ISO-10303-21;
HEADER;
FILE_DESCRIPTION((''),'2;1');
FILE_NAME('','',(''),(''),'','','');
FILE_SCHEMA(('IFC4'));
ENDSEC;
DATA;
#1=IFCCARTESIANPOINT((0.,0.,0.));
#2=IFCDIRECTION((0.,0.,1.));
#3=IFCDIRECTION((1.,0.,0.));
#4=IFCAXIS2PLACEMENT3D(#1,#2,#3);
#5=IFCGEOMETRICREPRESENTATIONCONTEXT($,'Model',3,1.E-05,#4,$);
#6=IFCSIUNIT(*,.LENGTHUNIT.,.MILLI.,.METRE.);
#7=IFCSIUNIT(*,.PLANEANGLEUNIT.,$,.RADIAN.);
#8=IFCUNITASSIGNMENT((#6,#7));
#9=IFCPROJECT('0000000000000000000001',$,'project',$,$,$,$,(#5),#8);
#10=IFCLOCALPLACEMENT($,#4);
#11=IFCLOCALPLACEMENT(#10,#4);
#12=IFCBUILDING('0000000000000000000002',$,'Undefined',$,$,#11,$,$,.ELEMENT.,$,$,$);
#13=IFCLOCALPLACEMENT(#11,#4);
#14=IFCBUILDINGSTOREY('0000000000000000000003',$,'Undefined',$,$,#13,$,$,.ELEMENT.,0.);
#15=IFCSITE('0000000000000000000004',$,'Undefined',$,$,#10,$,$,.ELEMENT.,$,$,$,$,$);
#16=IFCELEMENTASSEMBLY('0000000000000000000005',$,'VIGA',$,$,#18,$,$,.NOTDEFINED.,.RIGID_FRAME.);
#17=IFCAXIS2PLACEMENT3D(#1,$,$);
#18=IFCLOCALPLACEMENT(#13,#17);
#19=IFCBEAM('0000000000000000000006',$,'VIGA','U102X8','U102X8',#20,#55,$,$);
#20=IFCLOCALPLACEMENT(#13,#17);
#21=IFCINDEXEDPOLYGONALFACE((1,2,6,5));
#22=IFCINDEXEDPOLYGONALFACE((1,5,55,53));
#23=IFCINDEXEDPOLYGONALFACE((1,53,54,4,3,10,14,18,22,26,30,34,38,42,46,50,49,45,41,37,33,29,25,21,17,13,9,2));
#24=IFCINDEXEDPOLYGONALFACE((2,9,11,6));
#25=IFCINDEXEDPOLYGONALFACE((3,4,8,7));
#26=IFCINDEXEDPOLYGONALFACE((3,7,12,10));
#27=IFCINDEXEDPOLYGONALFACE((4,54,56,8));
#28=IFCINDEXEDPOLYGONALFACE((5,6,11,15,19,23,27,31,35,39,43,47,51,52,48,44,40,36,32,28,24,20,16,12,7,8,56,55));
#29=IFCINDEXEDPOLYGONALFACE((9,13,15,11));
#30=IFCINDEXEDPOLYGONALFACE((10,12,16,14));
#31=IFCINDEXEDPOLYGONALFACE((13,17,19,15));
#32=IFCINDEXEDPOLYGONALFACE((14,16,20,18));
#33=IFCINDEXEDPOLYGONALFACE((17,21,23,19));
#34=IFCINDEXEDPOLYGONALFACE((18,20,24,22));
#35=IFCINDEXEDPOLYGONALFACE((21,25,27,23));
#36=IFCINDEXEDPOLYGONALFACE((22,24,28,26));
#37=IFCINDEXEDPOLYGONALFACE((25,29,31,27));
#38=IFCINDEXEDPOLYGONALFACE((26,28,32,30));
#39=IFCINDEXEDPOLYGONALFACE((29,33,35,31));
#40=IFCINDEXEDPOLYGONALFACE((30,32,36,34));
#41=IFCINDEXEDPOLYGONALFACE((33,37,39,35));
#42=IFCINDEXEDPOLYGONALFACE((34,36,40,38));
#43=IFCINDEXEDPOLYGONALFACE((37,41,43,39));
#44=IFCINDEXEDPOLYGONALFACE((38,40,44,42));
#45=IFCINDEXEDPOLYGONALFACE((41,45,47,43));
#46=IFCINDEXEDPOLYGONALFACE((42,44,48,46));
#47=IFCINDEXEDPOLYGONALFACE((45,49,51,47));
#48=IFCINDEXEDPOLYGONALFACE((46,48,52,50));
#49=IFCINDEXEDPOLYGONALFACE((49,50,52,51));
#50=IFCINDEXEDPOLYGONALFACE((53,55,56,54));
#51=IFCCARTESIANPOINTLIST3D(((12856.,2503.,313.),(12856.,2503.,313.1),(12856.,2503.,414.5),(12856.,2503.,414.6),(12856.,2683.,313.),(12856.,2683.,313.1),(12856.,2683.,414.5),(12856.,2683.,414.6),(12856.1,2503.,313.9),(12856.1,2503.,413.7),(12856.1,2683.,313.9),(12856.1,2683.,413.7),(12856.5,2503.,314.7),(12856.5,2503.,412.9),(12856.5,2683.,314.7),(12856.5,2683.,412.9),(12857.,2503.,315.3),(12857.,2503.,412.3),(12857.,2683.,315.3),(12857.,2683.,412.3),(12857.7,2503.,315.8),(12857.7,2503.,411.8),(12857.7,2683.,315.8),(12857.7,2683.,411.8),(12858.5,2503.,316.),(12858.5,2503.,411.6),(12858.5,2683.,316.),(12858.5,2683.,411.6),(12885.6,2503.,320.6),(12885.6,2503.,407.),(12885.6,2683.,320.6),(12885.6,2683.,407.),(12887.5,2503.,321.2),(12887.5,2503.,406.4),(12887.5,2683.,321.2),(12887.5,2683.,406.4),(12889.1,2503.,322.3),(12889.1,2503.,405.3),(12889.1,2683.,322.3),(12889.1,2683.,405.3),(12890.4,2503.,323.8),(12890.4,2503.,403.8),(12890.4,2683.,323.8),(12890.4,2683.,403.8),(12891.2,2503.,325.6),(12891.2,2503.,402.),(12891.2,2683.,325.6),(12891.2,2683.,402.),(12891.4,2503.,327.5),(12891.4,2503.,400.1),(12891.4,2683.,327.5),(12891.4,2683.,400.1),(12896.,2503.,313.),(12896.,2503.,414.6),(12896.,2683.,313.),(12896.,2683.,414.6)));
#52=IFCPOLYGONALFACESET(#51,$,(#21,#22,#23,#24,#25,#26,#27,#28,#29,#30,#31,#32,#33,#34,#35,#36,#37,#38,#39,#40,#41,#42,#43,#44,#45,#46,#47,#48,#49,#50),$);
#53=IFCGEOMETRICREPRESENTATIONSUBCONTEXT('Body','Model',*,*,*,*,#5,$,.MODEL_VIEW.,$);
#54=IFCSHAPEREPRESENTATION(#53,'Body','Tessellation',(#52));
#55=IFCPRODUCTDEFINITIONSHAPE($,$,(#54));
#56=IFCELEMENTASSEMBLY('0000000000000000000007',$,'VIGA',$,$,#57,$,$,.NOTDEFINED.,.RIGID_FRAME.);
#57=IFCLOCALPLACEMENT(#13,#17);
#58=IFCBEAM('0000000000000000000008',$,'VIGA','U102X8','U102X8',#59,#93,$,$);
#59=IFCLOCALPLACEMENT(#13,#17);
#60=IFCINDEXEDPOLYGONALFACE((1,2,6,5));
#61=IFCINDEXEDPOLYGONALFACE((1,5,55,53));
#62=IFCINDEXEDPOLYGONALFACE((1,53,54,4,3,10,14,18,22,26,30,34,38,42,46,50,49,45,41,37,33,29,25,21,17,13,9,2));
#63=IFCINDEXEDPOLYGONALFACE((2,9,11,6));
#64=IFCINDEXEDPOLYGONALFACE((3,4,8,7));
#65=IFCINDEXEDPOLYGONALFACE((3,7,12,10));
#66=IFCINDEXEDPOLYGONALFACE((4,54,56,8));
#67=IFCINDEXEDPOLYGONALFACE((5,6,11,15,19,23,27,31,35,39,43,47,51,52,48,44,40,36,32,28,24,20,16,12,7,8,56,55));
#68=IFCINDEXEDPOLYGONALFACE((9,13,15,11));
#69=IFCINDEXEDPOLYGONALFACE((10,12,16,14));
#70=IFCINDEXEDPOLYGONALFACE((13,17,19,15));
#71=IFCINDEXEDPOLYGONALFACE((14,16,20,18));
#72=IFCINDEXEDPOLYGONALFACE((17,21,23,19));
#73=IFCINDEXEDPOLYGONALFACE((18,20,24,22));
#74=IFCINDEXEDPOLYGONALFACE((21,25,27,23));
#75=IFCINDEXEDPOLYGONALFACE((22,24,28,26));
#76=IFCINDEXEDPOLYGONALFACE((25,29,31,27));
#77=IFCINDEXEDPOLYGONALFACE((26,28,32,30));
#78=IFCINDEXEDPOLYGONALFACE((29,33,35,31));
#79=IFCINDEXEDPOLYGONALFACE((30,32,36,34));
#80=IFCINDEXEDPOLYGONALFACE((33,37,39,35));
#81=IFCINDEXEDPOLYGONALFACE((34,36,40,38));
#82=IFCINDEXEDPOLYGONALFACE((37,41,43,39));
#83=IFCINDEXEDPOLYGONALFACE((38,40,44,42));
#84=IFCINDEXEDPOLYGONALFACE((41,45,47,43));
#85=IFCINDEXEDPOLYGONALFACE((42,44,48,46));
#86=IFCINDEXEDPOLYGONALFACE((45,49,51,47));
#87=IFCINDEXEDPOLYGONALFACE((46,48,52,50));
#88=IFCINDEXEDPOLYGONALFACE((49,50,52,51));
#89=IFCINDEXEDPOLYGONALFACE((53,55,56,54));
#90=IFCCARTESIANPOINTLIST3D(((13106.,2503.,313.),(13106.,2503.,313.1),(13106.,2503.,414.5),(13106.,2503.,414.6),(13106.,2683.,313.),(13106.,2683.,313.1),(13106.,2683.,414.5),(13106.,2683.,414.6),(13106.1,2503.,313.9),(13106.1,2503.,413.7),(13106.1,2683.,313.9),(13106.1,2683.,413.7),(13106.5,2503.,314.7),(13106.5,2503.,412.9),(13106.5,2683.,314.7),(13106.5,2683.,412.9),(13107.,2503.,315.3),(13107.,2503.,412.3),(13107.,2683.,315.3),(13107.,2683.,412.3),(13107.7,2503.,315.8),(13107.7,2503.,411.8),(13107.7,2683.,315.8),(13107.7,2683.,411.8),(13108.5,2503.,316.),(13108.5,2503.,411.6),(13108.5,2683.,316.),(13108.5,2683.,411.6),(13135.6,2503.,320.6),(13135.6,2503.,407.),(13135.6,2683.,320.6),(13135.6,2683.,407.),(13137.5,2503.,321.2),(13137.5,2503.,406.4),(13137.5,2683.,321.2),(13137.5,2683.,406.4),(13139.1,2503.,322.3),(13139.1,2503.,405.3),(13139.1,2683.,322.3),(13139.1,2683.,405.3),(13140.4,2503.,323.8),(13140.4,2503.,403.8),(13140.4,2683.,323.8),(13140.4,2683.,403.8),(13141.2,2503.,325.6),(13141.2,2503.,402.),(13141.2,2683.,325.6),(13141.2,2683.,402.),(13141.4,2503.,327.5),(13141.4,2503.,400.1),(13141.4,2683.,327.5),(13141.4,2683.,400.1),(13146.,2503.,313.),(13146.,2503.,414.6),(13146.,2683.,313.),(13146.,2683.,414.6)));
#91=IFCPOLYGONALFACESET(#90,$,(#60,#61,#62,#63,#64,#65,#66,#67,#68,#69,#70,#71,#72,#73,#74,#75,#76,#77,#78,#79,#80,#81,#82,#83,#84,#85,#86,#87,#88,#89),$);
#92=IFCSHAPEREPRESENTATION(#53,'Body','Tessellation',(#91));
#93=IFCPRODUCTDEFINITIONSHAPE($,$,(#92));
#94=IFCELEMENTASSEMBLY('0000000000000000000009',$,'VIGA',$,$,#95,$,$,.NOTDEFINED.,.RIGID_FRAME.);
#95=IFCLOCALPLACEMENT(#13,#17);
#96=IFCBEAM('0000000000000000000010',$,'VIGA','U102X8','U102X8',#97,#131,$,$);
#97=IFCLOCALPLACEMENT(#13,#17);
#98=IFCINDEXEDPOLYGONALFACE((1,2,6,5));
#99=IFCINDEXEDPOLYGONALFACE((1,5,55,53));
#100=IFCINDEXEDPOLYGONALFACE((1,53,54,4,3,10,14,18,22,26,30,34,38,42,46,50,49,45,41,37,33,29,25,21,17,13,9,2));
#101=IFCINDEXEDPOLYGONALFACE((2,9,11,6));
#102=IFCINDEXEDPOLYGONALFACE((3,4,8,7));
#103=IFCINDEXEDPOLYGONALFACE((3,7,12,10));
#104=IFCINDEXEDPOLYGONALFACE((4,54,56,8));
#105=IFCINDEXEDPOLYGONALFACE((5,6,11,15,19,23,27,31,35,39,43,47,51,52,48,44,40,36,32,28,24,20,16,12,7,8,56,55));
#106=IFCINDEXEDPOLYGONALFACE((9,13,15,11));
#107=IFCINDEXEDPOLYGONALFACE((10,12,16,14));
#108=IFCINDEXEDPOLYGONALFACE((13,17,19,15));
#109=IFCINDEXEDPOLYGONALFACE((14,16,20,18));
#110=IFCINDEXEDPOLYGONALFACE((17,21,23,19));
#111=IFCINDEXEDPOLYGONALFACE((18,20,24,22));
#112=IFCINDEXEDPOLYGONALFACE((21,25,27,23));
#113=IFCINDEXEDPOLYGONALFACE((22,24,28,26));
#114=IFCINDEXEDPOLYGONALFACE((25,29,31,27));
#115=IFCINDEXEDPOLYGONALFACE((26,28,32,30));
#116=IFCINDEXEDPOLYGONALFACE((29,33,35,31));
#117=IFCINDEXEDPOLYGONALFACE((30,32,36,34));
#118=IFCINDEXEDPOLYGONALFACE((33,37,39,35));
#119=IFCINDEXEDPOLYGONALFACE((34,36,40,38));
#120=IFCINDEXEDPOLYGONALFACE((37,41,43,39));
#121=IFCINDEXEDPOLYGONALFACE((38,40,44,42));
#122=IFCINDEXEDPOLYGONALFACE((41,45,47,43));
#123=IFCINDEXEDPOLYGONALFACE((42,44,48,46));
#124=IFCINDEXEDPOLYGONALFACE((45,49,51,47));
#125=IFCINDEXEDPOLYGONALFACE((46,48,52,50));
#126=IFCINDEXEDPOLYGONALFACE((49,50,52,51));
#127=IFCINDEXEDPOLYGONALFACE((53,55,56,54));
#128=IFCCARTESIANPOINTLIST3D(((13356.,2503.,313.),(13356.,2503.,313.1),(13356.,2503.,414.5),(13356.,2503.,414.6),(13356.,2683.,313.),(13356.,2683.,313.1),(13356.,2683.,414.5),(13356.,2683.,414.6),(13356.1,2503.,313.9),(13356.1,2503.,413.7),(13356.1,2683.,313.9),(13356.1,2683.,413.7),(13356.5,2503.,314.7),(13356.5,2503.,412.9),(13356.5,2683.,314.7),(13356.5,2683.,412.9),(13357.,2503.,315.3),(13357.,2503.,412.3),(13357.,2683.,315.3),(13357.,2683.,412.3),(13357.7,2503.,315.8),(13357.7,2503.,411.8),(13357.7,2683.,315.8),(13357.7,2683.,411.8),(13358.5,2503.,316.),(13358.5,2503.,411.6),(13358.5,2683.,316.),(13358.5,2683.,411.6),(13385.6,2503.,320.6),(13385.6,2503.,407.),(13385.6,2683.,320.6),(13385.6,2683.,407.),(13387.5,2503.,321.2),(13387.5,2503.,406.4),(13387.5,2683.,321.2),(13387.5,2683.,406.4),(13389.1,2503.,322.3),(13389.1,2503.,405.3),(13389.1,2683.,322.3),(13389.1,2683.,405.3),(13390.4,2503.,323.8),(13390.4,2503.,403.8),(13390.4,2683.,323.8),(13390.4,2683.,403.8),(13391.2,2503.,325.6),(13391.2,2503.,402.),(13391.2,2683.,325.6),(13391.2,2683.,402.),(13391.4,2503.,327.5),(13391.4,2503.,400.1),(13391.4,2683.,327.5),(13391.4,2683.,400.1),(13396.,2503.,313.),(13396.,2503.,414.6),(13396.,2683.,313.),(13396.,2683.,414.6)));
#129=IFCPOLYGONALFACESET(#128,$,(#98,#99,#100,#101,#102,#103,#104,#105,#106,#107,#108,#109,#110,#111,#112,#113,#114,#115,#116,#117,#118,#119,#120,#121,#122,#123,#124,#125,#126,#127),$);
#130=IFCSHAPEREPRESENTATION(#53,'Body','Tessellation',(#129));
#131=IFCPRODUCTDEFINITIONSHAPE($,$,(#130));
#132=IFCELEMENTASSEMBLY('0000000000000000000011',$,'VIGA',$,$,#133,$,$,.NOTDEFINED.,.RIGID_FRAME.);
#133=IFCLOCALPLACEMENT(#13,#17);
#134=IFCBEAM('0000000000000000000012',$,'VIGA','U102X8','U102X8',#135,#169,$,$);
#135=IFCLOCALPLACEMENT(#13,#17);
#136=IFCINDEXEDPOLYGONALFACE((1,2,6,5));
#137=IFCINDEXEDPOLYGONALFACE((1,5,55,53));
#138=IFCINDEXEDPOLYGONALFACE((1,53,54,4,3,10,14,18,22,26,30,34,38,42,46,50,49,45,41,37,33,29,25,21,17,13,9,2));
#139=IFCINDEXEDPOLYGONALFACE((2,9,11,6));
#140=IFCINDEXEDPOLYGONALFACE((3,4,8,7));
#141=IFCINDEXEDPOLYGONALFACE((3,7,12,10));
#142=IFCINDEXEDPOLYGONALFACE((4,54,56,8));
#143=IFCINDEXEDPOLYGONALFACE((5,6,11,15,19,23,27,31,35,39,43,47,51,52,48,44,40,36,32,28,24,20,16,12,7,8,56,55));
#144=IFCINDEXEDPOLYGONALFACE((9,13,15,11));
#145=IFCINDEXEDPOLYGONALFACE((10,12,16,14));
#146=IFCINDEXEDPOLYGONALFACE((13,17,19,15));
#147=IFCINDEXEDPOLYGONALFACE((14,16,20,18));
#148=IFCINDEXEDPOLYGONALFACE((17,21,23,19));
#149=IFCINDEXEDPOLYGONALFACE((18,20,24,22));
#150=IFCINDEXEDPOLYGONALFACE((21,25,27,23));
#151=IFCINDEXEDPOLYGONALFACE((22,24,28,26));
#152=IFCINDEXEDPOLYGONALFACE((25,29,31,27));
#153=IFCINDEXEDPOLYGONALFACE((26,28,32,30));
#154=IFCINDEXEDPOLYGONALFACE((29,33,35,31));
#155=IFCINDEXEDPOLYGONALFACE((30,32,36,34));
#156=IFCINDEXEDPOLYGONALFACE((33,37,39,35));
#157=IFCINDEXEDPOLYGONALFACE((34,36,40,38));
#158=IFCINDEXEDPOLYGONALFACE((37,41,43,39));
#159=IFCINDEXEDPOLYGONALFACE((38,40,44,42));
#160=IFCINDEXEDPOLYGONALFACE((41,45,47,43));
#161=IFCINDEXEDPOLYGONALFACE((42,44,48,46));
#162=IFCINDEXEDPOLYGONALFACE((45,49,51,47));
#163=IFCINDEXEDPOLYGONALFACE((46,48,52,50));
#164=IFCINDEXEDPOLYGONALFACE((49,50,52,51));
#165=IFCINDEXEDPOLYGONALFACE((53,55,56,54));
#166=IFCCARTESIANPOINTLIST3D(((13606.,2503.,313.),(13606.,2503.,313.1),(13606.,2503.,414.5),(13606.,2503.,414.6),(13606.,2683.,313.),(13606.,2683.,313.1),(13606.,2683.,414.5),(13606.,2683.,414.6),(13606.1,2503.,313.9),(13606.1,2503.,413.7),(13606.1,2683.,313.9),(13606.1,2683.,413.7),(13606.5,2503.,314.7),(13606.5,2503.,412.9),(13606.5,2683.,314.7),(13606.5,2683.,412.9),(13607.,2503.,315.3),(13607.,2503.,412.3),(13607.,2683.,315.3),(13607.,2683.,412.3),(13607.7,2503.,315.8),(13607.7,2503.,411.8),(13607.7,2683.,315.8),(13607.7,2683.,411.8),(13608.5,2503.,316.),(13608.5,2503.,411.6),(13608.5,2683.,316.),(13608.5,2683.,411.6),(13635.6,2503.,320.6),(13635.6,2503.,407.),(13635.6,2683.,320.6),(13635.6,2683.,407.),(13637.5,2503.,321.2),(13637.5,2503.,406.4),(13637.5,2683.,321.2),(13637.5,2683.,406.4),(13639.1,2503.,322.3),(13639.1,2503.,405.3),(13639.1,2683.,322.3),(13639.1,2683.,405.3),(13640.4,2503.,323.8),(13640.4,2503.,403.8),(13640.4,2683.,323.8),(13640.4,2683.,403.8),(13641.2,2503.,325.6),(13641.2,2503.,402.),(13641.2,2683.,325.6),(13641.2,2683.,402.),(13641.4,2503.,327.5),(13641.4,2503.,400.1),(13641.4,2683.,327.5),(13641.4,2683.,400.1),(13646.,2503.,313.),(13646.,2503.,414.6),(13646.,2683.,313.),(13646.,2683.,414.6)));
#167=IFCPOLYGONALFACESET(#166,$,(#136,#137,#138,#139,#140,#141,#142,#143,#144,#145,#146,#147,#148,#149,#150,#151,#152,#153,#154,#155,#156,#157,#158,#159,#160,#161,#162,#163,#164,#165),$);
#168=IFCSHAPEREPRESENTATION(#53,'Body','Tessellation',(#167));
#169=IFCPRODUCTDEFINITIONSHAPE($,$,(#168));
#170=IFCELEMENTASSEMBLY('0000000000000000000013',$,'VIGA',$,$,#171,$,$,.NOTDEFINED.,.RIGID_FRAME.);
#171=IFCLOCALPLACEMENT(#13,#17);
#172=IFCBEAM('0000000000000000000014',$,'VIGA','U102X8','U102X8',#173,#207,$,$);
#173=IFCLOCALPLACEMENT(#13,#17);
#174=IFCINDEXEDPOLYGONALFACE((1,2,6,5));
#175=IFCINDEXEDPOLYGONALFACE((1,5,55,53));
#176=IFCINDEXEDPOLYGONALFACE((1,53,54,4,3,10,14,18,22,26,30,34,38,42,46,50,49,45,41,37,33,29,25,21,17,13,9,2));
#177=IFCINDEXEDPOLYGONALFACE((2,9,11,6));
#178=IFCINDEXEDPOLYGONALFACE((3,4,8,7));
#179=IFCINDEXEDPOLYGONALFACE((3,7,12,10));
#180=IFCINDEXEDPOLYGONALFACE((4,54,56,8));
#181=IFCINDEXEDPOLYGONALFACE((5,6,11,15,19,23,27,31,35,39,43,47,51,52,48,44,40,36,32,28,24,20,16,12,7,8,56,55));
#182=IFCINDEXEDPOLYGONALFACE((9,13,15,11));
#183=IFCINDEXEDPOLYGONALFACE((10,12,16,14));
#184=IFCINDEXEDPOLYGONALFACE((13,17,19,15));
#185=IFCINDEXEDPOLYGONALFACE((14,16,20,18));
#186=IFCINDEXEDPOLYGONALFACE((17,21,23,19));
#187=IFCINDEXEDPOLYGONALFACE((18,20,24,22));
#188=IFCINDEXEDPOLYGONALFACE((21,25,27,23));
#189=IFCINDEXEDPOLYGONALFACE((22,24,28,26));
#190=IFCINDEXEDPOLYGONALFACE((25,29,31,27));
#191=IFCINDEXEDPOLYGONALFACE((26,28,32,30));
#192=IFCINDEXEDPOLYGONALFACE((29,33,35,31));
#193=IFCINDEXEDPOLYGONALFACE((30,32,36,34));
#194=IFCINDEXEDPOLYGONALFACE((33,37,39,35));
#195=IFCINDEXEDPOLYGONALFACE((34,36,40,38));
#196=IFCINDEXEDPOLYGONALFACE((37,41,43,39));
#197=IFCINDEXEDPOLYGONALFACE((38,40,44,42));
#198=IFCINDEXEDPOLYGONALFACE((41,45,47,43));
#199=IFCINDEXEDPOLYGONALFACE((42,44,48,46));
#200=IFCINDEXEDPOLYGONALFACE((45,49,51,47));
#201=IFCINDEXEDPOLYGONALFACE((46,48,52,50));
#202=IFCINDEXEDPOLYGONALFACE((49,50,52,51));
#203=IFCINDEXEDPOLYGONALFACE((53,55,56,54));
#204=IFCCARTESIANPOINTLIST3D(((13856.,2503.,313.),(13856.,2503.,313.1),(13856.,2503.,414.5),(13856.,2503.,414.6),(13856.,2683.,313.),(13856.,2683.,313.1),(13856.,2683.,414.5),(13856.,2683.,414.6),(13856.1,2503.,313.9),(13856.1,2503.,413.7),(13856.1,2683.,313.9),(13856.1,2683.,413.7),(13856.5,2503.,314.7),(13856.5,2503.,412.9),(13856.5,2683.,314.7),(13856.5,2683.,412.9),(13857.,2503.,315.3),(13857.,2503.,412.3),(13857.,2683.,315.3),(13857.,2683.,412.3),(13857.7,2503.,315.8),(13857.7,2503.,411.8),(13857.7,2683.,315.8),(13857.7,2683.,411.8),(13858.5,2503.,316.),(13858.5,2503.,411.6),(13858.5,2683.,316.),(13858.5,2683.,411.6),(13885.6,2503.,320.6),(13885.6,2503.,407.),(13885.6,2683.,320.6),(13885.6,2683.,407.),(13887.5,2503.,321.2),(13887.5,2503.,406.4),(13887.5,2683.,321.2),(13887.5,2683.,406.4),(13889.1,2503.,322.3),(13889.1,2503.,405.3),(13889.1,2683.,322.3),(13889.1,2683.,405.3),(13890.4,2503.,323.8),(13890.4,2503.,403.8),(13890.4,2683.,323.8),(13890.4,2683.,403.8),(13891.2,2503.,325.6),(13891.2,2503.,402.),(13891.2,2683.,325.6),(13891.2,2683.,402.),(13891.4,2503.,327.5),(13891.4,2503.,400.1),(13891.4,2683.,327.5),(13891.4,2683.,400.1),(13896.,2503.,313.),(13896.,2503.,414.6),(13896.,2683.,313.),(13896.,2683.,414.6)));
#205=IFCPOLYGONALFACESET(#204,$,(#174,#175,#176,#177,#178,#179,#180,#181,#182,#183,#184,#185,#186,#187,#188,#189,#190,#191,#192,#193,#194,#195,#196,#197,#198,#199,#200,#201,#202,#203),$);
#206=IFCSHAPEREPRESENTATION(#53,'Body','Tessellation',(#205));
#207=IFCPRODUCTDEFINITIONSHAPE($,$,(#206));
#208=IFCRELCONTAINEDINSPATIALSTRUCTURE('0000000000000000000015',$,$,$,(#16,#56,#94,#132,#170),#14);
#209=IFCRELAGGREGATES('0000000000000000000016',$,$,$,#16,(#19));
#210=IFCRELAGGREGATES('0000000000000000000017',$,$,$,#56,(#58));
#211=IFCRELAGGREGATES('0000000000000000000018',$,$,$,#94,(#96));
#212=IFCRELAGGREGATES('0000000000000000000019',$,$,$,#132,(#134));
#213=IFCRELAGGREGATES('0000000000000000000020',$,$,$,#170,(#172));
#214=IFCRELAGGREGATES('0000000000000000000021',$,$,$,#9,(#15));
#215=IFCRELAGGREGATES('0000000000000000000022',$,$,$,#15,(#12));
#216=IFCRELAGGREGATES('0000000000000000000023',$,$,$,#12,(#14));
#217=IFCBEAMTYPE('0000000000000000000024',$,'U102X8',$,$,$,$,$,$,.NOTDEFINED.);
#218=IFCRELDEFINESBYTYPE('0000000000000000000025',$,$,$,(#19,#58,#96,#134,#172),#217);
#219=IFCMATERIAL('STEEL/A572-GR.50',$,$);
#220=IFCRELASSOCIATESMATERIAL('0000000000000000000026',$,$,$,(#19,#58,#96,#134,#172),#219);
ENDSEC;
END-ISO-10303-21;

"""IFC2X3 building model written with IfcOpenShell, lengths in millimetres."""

from ifc_helpers import new_model, si_unit, frame, origin_with_axes, origin_2d_with_axis, place, context, subcontext, project, spatial, u_section, extrude, material, type_object, element, aggregate, save


model = new_model("IFC2X3")

# Units and contexts
model_context = context("Model", 3, precision=1e-05, world=origin_with_axes())
body_context = subcontext(model_context, "Body", "Model", "MODEL_VIEW")
ifc_project = project(units=[si_unit("LENGTHUNIT", "METRE", prefix="MILLI"), si_unit("PLANEANGLEUNIT", "RADIAN")], contexts=[model_context])

# Site, building, storey
site_placement = place(None, origin_with_axes())
site = spatial("IfcSite", under=ifc_project, at=site_placement, Name="Undefined", CompositionType="ELEMENT")
building_placement = place(site_placement, origin_with_axes())
building = spatial("IfcBuilding", under=site, at=building_placement, Name="Undefined", CompositionType="ELEMENT")
storey_placement = place(building_placement, origin_with_axes())
storey = spatial("IfcBuildingStorey", under=building, at=storey_placement, Name="Undefined", CompositionType="ELEMENT", Elevation=0.0)

# Element assemblies, beams
ifc_material_1 = material(Name="STEEL/A572-GR.50")
beam_type_1 = type_object("IfcBeamType", Name="U102X8", PredefinedType="NOTDEFINED")
assembly_1_placement = place(storey_placement, origin_with_axes())
assembly_1 = element("IfcElementAssembly", 1, at=assembly_1_placement, inside=storey, Name="VIGA", AssemblyPlace="NOTDEFINED", PredefinedType="RIGID_FRAME")
beam_1_placement = place(assembly_1_placement, frame((12876.0, 2683.0, 363.8), z_axis=(0.0, 0.0, 1.0), x_axis=(0.0, -1.0, 0.0)))
beam_1 = element("IfcBeam", 2, at=beam_1_placement, type_object=beam_type_1, material=ifc_material_1, Name="VIGA", Description="U102X8", ObjectType="U102X8", context=body_context, shape_type="SweptSolid", body=[
    extrude(u_section(Depth=101.6, FlangeWidth=40.0, WebThickness=4.6, FlangeThickness=6.0, FilletRadius=7.0, EdgeRadius=3.0, FlangeSlope=0.16839, at=origin_2d_with_axis()), frame((180.0, 0.0, 0.0), z_axis=(-1.0, 0.0, 0.0), x_axis=(0.0, -1.0, 0.0)), (0.0, 0.0, 1.0), 180.0),
])
aggregate(assembly_1, [beam_1])
assembly_2_placement = place(storey_placement, origin_with_axes())
assembly_2 = element("IfcElementAssembly", 3, at=assembly_2_placement, inside=storey, Name="VIGA", AssemblyPlace="NOTDEFINED", PredefinedType="RIGID_FRAME")
beam_2_placement = place(assembly_2_placement, frame((13126.0, 2683.0, 363.8), z_axis=(0.0, 0.0, 1.0), x_axis=(0.0, -1.0, 0.0)))
beam_2 = element("IfcBeam", 4, at=beam_2_placement, type_object=beam_type_1, material=ifc_material_1, Name="VIGA", Description="U102X8", ObjectType="U102X8", context=body_context, shape_type="SweptSolid", body=[
    extrude(u_section(Depth=101.6, FlangeWidth=40.0, WebThickness=4.6, FlangeThickness=6.0, FilletRadius=7.0, EdgeRadius=3.0, FlangeSlope=0.16839, at=origin_2d_with_axis()), frame((180.0, 0.0, 0.0), z_axis=(-1.0, 0.0, 0.0), x_axis=(0.0, -1.0, 0.0)), (0.0, 0.0, 1.0), 180.0),
])
aggregate(assembly_2, [beam_2])
assembly_3_placement = place(storey_placement, origin_with_axes())
assembly_3 = element("IfcElementAssembly", 5, at=assembly_3_placement, inside=storey, Name="VIGA", AssemblyPlace="NOTDEFINED", PredefinedType="RIGID_FRAME")
beam_3_placement = place(assembly_3_placement, frame((13376.0, 2683.0, 363.8), z_axis=(0.0, 0.0, 1.0), x_axis=(0.0, -1.0, 0.0)))
beam_3 = element("IfcBeam", 6, at=beam_3_placement, type_object=beam_type_1, material=ifc_material_1, Name="VIGA", Description="U102X8", ObjectType="U102X8", context=body_context, shape_type="SweptSolid", body=[
    extrude(u_section(Depth=101.6, FlangeWidth=40.0, WebThickness=4.6, FlangeThickness=6.0, FilletRadius=7.0, EdgeRadius=3.0, FlangeSlope=0.16839, at=origin_2d_with_axis()), frame((180.0, 0.0, 0.0), z_axis=(-1.0, 0.0, 0.0), x_axis=(0.0, -1.0, 0.0)), (0.0, 0.0, 1.0), 180.0),
])
aggregate(assembly_3, [beam_3])
assembly_4_placement = place(storey_placement, origin_with_axes())
assembly_4 = element("IfcElementAssembly", 7, at=assembly_4_placement, inside=storey, Name="VIGA", AssemblyPlace="NOTDEFINED", PredefinedType="RIGID_FRAME")
beam_4_placement = place(assembly_4_placement, frame((13626.0, 2683.0, 363.8), z_axis=(0.0, 0.0, 1.0), x_axis=(0.0, -1.0, 0.0)))
beam_4 = element("IfcBeam", 8, at=beam_4_placement, type_object=beam_type_1, material=ifc_material_1, Name="VIGA", Description="U102X8", ObjectType="U102X8", context=body_context, shape_type="SweptSolid", body=[
    extrude(u_section(Depth=101.6, FlangeWidth=40.0, WebThickness=4.6, FlangeThickness=6.0, FilletRadius=7.0, EdgeRadius=3.0, FlangeSlope=0.16839, at=origin_2d_with_axis()), frame((180.0, 0.0, 0.0), z_axis=(-1.0, 0.0, 0.0), x_axis=(0.0, -1.0, 0.0)), (0.0, 0.0, 1.0), 180.0),
])
aggregate(assembly_4, [beam_4])
assembly_5_placement = place(storey_placement, origin_with_axes())
assembly_5 = element("IfcElementAssembly", 9, at=assembly_5_placement, inside=storey, Name="VIGA", AssemblyPlace="NOTDEFINED", PredefinedType="RIGID_FRAME")
beam_5_placement = place(assembly_5_placement, frame((13876.0, 2683.0, 363.8), z_axis=(0.0, 0.0, 1.0), x_axis=(0.0, -1.0, 0.0)))
beam_5 = element("IfcBeam", 10, at=beam_5_placement, type_object=beam_type_1, material=ifc_material_1, Name="VIGA", Description="U102X8", ObjectType="U102X8", context=body_context, shape_type="SweptSolid", body=[
    extrude(u_section(Depth=101.6, FlangeWidth=40.0, WebThickness=4.6, FlangeThickness=6.0, FilletRadius=7.0, EdgeRadius=3.0, FlangeSlope=0.16839, at=origin_2d_with_axis()), frame((180.0, 0.0, 0.0), z_axis=(-1.0, 0.0, 0.0), x_axis=(0.0, -1.0, 0.0)), (0.0, 0.0, 1.0), 180.0),
])
aggregate(assembly_5, [beam_5])

save(model, "model.ifc")
